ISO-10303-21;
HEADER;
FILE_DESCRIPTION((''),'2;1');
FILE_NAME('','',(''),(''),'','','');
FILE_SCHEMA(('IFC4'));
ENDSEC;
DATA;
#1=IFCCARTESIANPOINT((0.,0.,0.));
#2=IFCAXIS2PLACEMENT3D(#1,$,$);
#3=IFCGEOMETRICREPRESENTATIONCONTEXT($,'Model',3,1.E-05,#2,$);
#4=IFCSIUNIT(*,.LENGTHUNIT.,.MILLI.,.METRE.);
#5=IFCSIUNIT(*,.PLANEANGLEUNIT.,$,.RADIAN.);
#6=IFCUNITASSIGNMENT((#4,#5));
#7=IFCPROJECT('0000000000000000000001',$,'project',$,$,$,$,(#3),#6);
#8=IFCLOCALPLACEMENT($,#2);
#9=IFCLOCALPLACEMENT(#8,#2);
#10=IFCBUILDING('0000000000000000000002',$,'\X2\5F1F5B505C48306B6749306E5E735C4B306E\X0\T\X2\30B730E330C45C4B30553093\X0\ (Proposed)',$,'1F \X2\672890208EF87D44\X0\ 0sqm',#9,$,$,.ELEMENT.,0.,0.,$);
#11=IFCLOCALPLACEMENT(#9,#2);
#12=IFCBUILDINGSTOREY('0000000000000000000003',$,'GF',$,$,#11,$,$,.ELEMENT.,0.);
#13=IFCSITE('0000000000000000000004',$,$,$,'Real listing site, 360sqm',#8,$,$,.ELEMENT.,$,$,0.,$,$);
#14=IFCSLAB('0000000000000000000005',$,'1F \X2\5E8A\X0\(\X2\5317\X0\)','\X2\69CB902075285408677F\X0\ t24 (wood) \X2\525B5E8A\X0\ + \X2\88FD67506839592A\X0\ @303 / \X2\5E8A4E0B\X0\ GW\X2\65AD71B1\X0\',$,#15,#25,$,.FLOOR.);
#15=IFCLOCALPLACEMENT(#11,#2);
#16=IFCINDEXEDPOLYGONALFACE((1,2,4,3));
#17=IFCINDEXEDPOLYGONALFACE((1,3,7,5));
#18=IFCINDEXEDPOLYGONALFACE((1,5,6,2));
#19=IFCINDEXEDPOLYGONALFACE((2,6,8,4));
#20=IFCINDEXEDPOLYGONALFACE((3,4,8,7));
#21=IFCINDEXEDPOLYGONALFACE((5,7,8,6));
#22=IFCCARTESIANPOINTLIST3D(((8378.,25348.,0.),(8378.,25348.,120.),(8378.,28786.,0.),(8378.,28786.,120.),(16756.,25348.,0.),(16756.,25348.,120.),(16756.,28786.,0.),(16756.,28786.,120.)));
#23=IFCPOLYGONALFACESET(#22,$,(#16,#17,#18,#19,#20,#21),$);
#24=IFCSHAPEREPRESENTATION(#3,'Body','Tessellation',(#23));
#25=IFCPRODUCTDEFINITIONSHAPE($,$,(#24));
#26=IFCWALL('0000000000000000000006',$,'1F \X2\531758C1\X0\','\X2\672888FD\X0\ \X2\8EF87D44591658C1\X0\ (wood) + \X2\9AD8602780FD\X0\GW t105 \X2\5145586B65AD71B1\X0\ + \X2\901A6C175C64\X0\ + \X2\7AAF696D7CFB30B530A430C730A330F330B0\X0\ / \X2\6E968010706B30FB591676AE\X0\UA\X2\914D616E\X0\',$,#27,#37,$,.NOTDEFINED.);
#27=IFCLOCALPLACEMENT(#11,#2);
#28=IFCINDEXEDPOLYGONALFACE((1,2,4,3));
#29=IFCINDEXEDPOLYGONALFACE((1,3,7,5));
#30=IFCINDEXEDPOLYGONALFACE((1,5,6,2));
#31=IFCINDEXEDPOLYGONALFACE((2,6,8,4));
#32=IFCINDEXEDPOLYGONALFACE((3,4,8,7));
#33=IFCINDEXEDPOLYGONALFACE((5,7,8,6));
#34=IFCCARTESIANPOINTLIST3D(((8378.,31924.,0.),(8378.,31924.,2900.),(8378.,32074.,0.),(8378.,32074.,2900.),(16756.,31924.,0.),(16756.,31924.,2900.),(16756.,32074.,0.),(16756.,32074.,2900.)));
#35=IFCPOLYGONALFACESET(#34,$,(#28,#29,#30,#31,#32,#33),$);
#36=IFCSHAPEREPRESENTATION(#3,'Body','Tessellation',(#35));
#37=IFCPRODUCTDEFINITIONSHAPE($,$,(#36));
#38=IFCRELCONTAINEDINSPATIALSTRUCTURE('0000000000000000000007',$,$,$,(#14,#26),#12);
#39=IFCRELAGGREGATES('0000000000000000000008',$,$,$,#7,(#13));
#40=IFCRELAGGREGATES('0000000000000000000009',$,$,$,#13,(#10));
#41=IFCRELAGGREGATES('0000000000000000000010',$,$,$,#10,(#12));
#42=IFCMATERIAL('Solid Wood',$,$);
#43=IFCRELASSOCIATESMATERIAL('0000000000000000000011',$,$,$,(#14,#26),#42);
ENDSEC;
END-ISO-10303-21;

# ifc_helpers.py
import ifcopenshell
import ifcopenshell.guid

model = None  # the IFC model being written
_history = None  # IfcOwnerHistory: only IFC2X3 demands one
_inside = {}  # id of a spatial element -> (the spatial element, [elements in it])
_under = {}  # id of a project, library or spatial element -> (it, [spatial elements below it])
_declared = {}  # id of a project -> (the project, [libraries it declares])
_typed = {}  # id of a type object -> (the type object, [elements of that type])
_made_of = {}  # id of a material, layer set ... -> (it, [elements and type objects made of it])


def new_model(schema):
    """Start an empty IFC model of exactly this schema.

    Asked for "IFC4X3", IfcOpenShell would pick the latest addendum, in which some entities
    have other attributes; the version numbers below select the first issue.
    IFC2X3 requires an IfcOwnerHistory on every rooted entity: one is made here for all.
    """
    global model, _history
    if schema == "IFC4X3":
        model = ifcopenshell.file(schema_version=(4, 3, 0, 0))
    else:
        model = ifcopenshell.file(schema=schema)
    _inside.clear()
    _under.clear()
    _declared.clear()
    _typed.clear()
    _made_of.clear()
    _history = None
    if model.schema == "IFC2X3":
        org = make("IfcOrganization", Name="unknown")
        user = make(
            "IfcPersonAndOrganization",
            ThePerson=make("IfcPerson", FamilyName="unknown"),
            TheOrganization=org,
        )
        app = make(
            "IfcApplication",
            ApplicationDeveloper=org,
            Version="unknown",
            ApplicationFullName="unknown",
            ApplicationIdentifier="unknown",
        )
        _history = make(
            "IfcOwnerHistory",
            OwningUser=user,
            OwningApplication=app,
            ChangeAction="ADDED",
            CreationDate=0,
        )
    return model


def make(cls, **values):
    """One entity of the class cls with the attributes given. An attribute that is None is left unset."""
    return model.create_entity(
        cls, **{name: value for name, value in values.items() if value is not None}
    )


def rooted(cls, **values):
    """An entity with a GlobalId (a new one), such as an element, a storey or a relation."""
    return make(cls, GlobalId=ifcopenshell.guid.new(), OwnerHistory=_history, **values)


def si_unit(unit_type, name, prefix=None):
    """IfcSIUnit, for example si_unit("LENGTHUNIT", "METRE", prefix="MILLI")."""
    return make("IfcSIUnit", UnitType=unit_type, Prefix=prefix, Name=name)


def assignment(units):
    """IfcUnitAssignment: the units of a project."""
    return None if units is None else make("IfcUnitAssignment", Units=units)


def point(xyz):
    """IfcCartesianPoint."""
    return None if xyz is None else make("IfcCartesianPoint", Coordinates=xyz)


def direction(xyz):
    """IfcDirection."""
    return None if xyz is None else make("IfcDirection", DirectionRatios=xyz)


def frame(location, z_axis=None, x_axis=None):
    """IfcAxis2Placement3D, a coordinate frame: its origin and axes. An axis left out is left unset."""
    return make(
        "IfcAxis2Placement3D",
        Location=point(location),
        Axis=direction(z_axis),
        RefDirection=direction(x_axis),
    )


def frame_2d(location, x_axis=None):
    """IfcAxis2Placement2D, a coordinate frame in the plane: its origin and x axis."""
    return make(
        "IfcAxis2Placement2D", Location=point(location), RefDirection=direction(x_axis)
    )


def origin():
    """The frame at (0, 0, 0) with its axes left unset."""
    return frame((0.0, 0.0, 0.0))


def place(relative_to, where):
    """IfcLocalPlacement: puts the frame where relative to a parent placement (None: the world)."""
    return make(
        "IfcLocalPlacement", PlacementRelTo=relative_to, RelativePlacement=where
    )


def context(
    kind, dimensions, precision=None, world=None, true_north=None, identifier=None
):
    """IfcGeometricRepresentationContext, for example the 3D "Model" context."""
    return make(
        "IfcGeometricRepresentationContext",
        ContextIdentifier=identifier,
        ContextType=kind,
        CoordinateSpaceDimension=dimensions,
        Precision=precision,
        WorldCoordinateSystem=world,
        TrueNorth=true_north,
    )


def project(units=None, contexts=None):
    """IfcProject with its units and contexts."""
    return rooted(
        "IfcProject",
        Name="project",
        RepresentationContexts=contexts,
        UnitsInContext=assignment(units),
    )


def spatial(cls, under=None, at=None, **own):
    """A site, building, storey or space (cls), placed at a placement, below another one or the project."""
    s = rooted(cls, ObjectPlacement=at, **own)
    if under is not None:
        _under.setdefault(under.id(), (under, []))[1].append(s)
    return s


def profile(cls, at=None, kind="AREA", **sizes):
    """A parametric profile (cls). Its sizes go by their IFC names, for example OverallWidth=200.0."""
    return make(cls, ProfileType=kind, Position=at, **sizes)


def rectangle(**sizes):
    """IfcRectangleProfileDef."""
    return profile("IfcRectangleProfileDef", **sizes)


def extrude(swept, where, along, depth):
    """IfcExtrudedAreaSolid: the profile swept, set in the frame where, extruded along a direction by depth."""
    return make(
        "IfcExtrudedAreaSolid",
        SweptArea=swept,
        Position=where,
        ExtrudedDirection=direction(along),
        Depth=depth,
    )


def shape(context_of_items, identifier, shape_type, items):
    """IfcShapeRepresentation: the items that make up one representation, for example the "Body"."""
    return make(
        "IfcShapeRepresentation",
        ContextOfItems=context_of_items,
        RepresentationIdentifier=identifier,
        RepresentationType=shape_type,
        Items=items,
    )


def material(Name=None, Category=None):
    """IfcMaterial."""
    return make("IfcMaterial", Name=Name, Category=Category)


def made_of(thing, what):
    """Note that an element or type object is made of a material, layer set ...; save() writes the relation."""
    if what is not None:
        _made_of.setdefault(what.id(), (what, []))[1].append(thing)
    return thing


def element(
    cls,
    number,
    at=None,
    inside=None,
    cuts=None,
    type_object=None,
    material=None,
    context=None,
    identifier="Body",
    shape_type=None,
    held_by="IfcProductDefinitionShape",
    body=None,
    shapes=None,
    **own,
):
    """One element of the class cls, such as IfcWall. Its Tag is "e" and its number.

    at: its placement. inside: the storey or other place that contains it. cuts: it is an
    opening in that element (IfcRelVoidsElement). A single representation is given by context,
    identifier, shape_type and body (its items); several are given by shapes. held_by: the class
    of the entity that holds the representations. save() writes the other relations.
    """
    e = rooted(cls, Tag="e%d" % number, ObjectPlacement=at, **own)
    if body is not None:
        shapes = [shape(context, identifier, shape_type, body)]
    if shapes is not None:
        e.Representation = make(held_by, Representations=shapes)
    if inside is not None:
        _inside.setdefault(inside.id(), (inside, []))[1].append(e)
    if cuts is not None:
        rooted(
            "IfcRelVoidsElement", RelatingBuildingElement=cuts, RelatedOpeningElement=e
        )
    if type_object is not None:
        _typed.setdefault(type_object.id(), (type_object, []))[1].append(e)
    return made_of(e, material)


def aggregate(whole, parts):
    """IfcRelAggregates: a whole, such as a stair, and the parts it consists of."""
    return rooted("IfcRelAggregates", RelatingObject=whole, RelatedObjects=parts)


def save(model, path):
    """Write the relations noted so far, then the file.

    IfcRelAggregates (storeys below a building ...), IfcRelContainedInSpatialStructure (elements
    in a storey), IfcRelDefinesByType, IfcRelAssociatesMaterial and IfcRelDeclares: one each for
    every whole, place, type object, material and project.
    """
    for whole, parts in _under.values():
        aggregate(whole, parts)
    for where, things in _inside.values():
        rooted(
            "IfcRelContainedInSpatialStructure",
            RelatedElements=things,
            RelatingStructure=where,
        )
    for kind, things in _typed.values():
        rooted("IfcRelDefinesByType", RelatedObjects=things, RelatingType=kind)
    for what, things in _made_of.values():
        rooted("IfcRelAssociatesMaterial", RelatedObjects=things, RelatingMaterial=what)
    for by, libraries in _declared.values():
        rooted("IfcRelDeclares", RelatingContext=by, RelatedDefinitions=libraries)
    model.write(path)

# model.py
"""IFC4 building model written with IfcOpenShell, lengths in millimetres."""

from ifc_helpers import new_model, si_unit, frame, frame_2d, origin, place, context, project, spatial, rectangle, extrude, material, element, save


model = new_model("IFC4")

# Units and contexts
model_context = context("Model", 3, precision=1e-05, world=origin())
ifc_project = project(units=[si_unit("LENGTHUNIT", "METRE", prefix="MILLI"), si_unit("PLANEANGLEUNIT", "RADIAN")], contexts=[model_context])

# Site, building, storey
site_placement = place(None, origin())
site = spatial("IfcSite", under=ifc_project, at=site_placement, ObjectType="Real listing site, 360sqm", CompositionType="ELEMENT", RefElevation=0.0)
building_placement = place(site_placement, origin())
building = spatial("IfcBuilding", under=site, at=building_placement, Name="弟子屈に杉の平屋のTシャツ屋さん (Proposed)", ObjectType="1F 木造軸組 0sqm", CompositionType="ELEMENT", ElevationOfRefHeight=0.0, ElevationOfTerrain=0.0)
storey_placement = place(building_placement, origin())
storey = spatial("IfcBuildingStorey", under=building, at=storey_placement, Name="GF", CompositionType="ELEMENT", Elevation=0.0)

# Slab
ifc_material_1 = material(Name="Solid Wood")
slab_1_placement = place(storey_placement, frame((4189.0, 12674.0, 0.0)))
element("IfcSlab", 1, at=slab_1_placement, inside=storey, material=ifc_material_1, Name="1F 床(北)", Description="構造用合板 t24 (wood) 剛床 + 製材根太 @303 / 床下 GW断熱", PredefinedType="FLOOR", context=model_context, shape_type="SweptSolid", body=[
    extrude(rectangle(XDim=8378.0, YDim=3438.0, at=frame_2d((4189.0, 1719.0))), frame((4189.0, 12674.0, 0.0)), (0.0, 0.0, 1.0), 120.0),
])

# Wall
wall_1_placement = place(storey_placement, frame((4189.0, 15962.0, 0.0)))
element("IfcWall", 2, at=wall_1_placement, inside=storey, material=ifc_material_1, Name="1F 北壁", Description="木製 軸組外壁 (wood) + 高性能GW t105 充填断熱 + 通気層 + 窯業系サイディング / 準耐火・外皮UA配慮", PredefinedType="NOTDEFINED", context=model_context, shape_type="SweptSolid", body=[
    extrude(rectangle(XDim=8378.0, YDim=150.0, at=frame_2d((4189.0, 75.0))), frame((4189.0, 15962.0, 0.0)), (0.0, 0.0, 1.0), 2900.0),
])

save(model, "model.ifc")
